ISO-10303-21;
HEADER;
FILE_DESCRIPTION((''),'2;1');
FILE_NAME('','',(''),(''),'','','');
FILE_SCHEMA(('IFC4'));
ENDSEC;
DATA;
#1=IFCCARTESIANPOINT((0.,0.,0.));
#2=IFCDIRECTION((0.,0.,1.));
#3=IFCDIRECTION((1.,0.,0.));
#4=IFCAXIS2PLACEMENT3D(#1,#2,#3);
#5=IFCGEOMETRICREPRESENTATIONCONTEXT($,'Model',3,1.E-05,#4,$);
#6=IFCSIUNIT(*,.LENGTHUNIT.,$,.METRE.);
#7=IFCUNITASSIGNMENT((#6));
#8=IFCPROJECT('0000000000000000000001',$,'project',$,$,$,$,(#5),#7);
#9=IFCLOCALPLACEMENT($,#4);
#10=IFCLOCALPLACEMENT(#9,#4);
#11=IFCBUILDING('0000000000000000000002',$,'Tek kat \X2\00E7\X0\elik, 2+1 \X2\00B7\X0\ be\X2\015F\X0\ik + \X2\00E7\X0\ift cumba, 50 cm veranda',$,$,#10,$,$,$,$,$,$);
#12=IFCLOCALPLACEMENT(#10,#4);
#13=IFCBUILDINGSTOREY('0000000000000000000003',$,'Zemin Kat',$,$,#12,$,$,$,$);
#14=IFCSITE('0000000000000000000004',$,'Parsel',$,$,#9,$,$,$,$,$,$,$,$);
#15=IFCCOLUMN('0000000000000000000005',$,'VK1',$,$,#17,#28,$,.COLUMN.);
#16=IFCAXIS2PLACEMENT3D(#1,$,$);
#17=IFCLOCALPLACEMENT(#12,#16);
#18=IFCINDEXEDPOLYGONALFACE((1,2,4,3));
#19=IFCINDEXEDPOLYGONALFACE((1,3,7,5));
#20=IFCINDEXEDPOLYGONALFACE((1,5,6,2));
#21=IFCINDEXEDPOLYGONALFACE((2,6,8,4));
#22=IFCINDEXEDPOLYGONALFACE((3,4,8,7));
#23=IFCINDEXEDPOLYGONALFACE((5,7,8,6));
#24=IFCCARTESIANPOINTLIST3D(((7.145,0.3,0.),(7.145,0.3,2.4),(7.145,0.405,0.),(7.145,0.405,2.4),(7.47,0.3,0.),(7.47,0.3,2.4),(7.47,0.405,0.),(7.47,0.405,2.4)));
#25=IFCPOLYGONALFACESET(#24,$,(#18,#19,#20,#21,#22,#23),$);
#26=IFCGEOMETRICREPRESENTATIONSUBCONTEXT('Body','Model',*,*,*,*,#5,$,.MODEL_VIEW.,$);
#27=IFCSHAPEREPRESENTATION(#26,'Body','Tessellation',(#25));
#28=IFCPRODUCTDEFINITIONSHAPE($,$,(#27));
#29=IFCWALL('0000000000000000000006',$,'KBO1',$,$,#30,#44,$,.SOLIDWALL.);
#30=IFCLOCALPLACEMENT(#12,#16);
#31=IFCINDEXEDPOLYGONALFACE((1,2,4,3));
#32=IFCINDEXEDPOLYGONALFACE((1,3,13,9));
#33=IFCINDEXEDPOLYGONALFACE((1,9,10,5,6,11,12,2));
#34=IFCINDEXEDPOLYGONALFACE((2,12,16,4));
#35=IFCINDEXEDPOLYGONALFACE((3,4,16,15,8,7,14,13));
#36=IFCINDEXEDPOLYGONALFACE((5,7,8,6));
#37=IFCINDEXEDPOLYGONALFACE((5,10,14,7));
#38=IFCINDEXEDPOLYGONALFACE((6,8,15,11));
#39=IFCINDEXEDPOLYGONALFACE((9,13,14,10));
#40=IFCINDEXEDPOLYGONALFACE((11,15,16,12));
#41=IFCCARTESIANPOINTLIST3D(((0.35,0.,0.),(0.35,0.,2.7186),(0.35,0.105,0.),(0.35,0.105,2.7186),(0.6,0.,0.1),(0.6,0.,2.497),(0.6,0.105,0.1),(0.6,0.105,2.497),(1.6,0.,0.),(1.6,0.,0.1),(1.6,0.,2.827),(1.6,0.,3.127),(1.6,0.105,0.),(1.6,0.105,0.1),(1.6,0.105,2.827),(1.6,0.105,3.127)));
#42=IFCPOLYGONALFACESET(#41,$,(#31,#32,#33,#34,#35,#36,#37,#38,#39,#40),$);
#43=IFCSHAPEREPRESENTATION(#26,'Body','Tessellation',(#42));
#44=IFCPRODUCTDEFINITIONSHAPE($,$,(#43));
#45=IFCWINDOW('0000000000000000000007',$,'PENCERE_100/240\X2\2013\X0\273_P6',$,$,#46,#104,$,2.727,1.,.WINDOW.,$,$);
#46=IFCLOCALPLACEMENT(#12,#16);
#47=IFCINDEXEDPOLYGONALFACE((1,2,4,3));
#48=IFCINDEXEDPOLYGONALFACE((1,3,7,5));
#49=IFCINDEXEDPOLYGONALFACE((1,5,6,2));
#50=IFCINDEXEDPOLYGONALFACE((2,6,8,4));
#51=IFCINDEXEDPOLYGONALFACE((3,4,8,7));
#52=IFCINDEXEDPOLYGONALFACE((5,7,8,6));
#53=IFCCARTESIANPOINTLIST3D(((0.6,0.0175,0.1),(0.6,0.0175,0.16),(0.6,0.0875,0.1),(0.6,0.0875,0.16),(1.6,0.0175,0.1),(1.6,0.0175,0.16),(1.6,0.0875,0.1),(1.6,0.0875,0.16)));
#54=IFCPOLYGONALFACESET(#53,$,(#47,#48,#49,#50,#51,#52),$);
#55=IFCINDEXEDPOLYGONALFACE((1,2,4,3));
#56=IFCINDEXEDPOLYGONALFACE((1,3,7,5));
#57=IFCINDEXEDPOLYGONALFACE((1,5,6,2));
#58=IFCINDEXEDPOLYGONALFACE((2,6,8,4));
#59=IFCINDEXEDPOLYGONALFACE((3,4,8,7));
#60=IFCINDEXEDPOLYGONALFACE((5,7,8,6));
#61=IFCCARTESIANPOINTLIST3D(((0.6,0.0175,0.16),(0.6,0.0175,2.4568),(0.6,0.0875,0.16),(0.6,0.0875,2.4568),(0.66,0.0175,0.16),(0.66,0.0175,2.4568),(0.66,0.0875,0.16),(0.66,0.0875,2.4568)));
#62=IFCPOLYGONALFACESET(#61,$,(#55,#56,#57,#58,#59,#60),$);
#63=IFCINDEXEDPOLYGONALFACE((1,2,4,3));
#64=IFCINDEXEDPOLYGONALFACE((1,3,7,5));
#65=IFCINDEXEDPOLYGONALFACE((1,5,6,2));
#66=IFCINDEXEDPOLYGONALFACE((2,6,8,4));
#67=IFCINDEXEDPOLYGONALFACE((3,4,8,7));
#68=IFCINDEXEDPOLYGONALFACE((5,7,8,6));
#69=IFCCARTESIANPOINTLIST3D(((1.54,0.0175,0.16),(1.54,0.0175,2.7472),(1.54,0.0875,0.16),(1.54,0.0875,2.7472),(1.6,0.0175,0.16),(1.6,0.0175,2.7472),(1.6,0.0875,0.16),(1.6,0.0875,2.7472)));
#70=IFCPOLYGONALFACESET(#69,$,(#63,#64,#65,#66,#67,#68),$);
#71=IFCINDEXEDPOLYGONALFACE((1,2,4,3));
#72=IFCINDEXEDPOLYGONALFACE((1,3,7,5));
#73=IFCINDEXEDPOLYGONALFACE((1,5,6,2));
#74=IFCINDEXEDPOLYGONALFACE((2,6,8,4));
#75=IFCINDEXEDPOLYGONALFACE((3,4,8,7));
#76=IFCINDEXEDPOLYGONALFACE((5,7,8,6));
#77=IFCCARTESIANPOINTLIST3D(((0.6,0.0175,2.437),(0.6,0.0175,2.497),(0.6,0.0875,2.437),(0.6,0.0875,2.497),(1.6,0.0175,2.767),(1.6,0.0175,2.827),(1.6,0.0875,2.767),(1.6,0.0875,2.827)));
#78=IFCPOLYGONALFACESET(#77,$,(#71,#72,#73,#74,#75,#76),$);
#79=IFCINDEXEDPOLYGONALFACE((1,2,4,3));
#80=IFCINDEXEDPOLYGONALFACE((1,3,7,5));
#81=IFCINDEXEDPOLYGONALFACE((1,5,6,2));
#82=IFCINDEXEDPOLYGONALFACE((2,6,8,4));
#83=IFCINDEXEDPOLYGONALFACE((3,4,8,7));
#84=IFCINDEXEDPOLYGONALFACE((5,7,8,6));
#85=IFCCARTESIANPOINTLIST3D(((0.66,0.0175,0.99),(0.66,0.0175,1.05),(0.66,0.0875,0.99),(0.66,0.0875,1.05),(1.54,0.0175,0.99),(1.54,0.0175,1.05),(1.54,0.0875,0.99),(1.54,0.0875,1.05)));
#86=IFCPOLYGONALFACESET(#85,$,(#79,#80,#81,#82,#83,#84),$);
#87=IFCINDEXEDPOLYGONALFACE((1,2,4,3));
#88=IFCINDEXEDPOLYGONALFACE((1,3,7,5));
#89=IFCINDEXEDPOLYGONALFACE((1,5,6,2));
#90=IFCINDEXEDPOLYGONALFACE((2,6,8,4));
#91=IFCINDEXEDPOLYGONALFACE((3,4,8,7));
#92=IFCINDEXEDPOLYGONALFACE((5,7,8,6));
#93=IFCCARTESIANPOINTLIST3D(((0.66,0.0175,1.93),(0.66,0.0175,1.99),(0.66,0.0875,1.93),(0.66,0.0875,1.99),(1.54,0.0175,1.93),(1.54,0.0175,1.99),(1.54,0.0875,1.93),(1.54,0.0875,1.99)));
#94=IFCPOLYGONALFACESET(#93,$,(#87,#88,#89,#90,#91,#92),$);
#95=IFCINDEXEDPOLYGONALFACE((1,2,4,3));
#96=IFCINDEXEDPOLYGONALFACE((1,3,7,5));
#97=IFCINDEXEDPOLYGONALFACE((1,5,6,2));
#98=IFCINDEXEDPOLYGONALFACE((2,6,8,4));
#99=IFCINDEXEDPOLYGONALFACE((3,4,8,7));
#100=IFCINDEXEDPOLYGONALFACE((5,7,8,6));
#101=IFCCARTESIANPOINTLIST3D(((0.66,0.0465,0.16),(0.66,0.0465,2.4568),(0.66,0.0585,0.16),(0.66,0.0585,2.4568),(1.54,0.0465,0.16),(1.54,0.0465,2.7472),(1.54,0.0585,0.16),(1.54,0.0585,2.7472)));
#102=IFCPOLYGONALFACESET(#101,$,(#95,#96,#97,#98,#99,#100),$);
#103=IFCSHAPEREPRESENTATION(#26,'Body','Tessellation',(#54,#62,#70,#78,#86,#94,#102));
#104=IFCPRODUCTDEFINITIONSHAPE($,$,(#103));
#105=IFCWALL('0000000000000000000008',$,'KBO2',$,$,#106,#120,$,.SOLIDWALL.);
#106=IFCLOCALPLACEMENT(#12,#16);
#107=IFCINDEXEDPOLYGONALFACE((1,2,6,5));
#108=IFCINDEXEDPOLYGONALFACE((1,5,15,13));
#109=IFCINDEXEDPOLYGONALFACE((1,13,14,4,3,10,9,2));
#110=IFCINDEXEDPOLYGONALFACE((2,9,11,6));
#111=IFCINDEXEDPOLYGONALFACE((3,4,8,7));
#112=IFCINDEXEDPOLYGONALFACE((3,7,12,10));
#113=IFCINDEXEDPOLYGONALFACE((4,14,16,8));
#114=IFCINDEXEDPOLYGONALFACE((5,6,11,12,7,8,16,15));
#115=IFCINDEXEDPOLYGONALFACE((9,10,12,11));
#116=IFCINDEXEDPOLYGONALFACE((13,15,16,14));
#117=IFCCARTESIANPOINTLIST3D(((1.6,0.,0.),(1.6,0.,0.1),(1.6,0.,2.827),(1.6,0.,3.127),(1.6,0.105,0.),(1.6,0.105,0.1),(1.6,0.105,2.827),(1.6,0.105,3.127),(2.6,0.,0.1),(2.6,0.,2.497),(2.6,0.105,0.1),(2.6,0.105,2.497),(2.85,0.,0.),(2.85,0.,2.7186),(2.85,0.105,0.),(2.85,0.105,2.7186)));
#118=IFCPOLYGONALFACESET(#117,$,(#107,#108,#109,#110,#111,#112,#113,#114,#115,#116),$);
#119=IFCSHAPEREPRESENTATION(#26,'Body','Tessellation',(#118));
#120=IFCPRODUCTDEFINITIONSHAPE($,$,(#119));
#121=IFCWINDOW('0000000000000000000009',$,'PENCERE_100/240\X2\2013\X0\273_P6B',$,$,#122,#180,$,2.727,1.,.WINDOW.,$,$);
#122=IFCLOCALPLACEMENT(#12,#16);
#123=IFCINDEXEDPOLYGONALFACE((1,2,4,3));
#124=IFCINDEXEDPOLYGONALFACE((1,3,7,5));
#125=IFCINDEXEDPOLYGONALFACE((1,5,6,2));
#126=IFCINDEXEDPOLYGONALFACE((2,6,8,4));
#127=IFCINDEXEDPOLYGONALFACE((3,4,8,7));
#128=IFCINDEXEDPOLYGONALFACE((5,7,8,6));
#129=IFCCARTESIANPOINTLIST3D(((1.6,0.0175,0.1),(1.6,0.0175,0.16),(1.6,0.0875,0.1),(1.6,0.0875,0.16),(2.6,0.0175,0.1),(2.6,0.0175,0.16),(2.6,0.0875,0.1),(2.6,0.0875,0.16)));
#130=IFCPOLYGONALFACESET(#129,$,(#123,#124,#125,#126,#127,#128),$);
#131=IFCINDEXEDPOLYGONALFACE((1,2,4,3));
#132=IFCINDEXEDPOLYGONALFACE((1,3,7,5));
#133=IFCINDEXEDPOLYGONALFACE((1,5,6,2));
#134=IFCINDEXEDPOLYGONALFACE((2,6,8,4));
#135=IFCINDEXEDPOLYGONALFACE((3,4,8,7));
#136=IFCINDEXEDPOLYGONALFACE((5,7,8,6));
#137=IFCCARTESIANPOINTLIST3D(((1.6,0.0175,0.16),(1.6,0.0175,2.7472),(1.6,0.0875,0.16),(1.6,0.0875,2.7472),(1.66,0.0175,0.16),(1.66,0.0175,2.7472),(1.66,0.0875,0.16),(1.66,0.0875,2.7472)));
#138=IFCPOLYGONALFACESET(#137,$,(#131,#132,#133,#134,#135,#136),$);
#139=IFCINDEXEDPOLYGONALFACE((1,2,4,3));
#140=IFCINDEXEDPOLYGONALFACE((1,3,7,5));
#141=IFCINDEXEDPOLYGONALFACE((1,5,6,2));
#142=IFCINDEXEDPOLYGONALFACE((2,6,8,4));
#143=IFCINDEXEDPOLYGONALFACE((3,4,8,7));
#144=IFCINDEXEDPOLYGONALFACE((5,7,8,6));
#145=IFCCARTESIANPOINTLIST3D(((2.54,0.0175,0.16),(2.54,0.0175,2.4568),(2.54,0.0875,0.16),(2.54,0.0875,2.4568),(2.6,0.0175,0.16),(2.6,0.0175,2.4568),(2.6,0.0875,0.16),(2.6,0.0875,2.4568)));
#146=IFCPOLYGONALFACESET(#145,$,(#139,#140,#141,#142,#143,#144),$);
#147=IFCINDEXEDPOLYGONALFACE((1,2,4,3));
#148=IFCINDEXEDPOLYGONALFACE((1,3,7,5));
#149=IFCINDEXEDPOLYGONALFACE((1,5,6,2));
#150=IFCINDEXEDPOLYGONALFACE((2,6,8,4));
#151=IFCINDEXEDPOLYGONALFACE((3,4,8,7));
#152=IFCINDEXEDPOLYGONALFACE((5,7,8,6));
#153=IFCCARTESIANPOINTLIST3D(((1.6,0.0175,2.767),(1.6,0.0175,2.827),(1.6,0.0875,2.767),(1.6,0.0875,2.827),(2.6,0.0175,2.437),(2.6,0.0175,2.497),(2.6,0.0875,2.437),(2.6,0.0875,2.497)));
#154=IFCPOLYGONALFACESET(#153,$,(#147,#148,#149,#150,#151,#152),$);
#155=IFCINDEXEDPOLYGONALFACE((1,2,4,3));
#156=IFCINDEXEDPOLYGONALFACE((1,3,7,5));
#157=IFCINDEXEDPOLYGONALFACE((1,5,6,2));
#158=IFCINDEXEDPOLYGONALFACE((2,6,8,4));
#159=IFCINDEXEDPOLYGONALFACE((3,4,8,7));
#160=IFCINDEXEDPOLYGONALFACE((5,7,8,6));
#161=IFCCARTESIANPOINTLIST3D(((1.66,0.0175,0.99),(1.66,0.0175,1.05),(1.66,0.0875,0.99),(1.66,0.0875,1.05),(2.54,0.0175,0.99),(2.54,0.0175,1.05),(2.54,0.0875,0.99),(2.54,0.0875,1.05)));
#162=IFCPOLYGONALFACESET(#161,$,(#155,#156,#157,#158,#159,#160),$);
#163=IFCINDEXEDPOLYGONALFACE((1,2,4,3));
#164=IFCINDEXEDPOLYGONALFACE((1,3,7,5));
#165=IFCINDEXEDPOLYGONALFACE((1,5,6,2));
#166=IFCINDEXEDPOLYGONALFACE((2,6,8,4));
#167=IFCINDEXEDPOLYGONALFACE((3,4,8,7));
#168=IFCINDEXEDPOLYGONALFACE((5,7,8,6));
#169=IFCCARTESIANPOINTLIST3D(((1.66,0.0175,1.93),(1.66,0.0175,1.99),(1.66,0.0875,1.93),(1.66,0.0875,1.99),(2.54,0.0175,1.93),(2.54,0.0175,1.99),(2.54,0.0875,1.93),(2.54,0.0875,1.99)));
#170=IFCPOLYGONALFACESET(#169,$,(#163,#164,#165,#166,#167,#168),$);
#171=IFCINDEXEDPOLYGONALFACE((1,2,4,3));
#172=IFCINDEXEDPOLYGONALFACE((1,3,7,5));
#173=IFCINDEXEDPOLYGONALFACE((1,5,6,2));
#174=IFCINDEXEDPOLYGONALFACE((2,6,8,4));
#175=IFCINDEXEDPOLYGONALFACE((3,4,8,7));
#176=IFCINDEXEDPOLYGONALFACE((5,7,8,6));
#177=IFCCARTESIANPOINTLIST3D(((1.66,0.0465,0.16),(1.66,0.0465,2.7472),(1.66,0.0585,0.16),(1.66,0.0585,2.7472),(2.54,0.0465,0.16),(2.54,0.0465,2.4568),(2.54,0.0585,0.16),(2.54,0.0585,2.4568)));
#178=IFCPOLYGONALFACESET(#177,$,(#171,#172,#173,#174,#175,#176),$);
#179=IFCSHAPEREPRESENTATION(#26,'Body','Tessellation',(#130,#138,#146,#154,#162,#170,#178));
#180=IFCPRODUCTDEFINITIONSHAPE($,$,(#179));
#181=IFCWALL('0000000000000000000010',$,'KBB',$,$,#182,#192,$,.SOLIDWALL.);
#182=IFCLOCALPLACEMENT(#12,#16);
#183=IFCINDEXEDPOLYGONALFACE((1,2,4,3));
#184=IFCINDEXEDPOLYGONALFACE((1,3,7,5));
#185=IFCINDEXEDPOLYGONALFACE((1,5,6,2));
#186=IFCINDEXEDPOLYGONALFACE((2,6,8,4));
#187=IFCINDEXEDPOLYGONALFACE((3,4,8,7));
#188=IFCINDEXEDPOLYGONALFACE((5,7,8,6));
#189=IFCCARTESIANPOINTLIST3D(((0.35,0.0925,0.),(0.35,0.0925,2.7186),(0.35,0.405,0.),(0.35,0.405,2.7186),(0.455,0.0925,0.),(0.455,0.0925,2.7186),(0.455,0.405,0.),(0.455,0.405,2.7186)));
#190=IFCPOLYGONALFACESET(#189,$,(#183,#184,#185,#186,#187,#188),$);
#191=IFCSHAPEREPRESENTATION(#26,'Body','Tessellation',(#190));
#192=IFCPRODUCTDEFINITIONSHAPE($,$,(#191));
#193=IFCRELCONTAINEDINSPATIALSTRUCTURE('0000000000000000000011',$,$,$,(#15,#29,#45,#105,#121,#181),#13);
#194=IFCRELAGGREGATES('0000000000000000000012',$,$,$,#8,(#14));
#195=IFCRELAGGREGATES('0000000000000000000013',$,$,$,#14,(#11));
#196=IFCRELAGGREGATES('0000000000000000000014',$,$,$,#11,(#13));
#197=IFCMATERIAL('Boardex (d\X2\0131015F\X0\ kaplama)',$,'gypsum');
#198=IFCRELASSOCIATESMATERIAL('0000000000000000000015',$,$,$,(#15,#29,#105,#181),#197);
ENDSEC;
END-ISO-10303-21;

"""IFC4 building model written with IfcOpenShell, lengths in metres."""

from ifc_helpers import new_model, si_unit, frame, origin_with_axes, place, context, subcontext, project, spatial, line, indexed_curve, outline, extrude, material, element, fill, save


model = new_model("IFC4")

# Units and contexts
model_context = context("Model", 3, precision=1e-05, world=origin_with_axes())
body_context = subcontext(model_context, "Body", "Model", "MODEL_VIEW")
ifc_project = project(units=[si_unit("LENGTHUNIT", "METRE")], contexts=[model_context])

# Site, building, storey
site_placement = place(None, origin_with_axes())
site = spatial("IfcSite", under=ifc_project, at=site_placement, Name="Parsel")
building_placement = place(site_placement, origin_with_axes())
building = spatial("IfcBuilding", under=site, at=building_placement, Name="Tek kat çelik, 2+1 · beşik + çift cumba, 50 cm veranda")
storey_placement = place(building_placement, origin_with_axes())
storey = spatial("IfcBuildingStorey", under=building, at=storey_placement, Name="Zemin Kat")

# Column
ifc_material_1 = material(Name="Boardex (dış kaplama)", Category="gypsum")
column_placement = place(storey_placement, origin_with_axes())
element("IfcColumn", 1, at=column_placement, inside=storey, material=ifc_material_1, Name="VK1", PredefinedType="COLUMN", context=body_context, shape_type="SweptSolid", body=[
    extrude(outline(indexed_curve([(0.0, 0.0), (0.325, 0.0), (0.325, 0.105), (0.0, 0.105)], segments=[line(1, 2, 3, 4, 1)])), frame((7.145, 0.3, 0.0), z_axis=(0.0, 0.0, 1.0), x_axis=(1.0, 0.0, 0.0)), (0.0, 0.0, 1.0), 2.4),
])

# Walls, openings, windows
wall_1_placement = place(storey_placement, origin_with_axes())
wall_1 = element("IfcWall", 2, at=wall_1_placement, inside=storey, material=ifc_material_1, Name="KBO1", PredefinedType="SOLIDWALL", context=body_context, shape_type="SweptSolid", body=[
    extrude(outline(indexed_curve([(0.35, 0.0), (1.6, 0.0), (1.6, 3.127), (0.35, 2.7186)], segments=[line(1, 2, 3, 4, 1)])), frame((0.0, 0.105, 0.0), z_axis=(0.0, -1.0, 0.0), x_axis=(1.0, 0.0, 0.0)), (0.0, 0.0, 1.0), 0.105),
])
opening_1_placement = place(wall_1_placement, origin_with_axes())
opening_1 = element("IfcOpeningElement", 3, at=opening_1_placement, cuts=wall_1, PredefinedType="OPENING", context=body_context, shape_type="SweptSolid", body=[
    extrude(outline(indexed_curve([(0.6, 0.1), (1.6, 0.1), (1.6, 2.827), (0.6, 2.497)], segments=[line(1, 2, 3, 4, 1)])), frame((0.0, 0.125, 0.0), z_axis=(0.0, -1.0, 0.0), x_axis=(1.0, 0.0, 0.0)), (0.0, 0.0, 1.0), 0.145),
])
window_1_placement = place(storey_placement, origin_with_axes())
window_1 = element("IfcWindow", 4, at=window_1_placement, inside=storey, Name="PENCERE_100/240–273_P6", OverallHeight=2.727, OverallWidth=1.0, PredefinedType="WINDOW", context=body_context, shape_type="SweptSolid", body=[
    extrude(outline(indexed_curve([(0.0, 0.0), (1.0, 0.0), (1.0, 0.07), (0.0, 0.07)], segments=[line(1, 2, 3, 4, 1)])), frame((0.6, 0.0175, 0.1), z_axis=(0.0, 0.0, 1.0), x_axis=(1.0, 0.0, 0.0)), (0.0, 0.0, 1.0), 0.06),
    extrude(outline(indexed_curve([(0.0, 0.0), (0.06, 0.0), (0.06, 0.07), (0.0, 0.07)], segments=[line(1, 2, 3, 4, 1)])), frame((0.6, 0.0175, 0.16), z_axis=(0.0, 0.0, 1.0), x_axis=(1.0, 0.0, 0.0)), (0.0, 0.0, 1.0), 2.2968),
    extrude(outline(indexed_curve([(0.0, 0.0), (0.06, 0.0), (0.06, 0.07), (0.0, 0.07)], segments=[line(1, 2, 3, 4, 1)])), frame((1.54, 0.0175, 0.16), z_axis=(0.0, 0.0, 1.0), x_axis=(1.0, 0.0, 0.0)), (0.0, 0.0, 1.0), 2.5872),
    extrude(outline(indexed_curve([(0.6, 2.437), (1.6, 2.767), (1.6, 2.827), (0.6, 2.497)], segments=[line(1, 2, 3, 4, 1)])), frame((0.0, 0.0875, 0.0), z_axis=(0.0, -1.0, 0.0), x_axis=(1.0, 0.0, 0.0)), (0.0, 0.0, 1.0), 0.07),
    extrude(outline(indexed_curve([(0.0, 0.0), (0.88, 0.0), (0.88, 0.07), (0.0, 0.07)], segments=[line(1, 2, 3, 4, 1)])), frame((0.66, 0.0175, 0.99), z_axis=(0.0, 0.0, 1.0), x_axis=(1.0, 0.0, 0.0)), (0.0, 0.0, 1.0), 0.06),
    extrude(outline(indexed_curve([(0.0, 0.0), (0.88, 0.0), (0.88, 0.07), (0.0, 0.07)], segments=[line(1, 2, 3, 4, 1)])), frame((0.66, 0.0175, 1.93), z_axis=(0.0, 0.0, 1.0), x_axis=(1.0, 0.0, 0.0)), (0.0, 0.0, 1.0), 0.06),
    extrude(outline(indexed_curve([(0.66, 0.16), (1.54, 0.16), (1.54, 2.7472), (0.66, 2.4568)], segments=[line(1, 2, 3, 4, 1)])), frame((0.0, 0.0585, 0.0), z_axis=(0.0, -1.0, 0.0), x_axis=(1.0, 0.0, 0.0)), (0.0, 0.0, 1.0), 0.012),
])
fill(opening_1, window_1)
wall_2_placement = place(storey_placement, origin_with_axes())
wall_2 = element("IfcWall", 5, at=wall_2_placement, inside=storey, material=ifc_material_1, Name="KBO2", PredefinedType="SOLIDWALL", context=body_context, shape_type="SweptSolid", body=[
    extrude(outline(indexed_curve([(1.6, 0.0), (2.85, 0.0), (2.85, 2.7186), (1.6, 3.127)], segments=[line(1, 2, 3, 4, 1)])), frame((0.0, 0.105, 0.0), z_axis=(0.0, -1.0, 0.0), x_axis=(1.0, 0.0, 0.0)), (0.0, 0.0, 1.0), 0.105),
])
opening_2_placement = place(wall_2_placement, origin_with_axes())
opening_2 = element("IfcOpeningElement", 6, at=opening_2_placement, cuts=wall_2, PredefinedType="OPENING", context=body_context, shape_type="SweptSolid", body=[
    extrude(outline(indexed_curve([(1.6, 0.1), (2.6, 0.1), (2.6, 2.497), (1.6, 2.827)], segments=[line(1, 2, 3, 4, 1)])), frame((0.0, 0.125, 0.0), z_axis=(0.0, -1.0, 0.0), x_axis=(1.0, 0.0, 0.0)), (0.0, 0.0, 1.0), 0.145),
])
window_2_placement = place(storey_placement, origin_with_axes())
window_2 = element("IfcWindow", 7, at=window_2_placement, inside=storey, Name="PENCERE_100/240–273_P6B", OverallHeight=2.727, OverallWidth=1.0, PredefinedType="WINDOW", context=body_context, shape_type="SweptSolid", body=[
    extrude(outline(indexed_curve([(0.0, 0.0), (1.0, 0.0), (1.0, 0.07), (0.0, 0.07)], segments=[line(1, 2, 3, 4, 1)])), frame((1.6, 0.0175, 0.1), z_axis=(0.0, 0.0, 1.0), x_axis=(1.0, 0.0, 0.0)), (0.0, 0.0, 1.0), 0.06),
    extrude(outline(indexed_curve([(0.0, 0.0), (0.06, 0.0), (0.06, 0.07), (0.0, 0.07)], segments=[line(1, 2, 3, 4, 1)])), frame((1.6, 0.0175, 0.16), z_axis=(0.0, 0.0, 1.0), x_axis=(1.0, 0.0, 0.0)), (0.0, 0.0, 1.0), 2.5872),
    extrude(outline(indexed_curve([(0.0, 0.0), (0.06, 0.0), (0.06, 0.07), (0.0, 0.07)], segments=[line(1, 2, 3, 4, 1)])), frame((2.54, 0.0175, 0.16), z_axis=(0.0, 0.0, 1.0), x_axis=(1.0, 0.0, 0.0)), (0.0, 0.0, 1.0), 2.2968),
    extrude(outline(indexed_curve([(1.6, 2.767), (2.6, 2.437), (2.6, 2.497), (1.6, 2.827)], segments=[line(1, 2, 3, 4, 1)])), frame((0.0, 0.0875, 0.0), z_axis=(0.0, -1.0, 0.0), x_axis=(1.0, 0.0, 0.0)), (0.0, 0.0, 1.0), 0.07),
    extrude(outline(indexed_curve([(0.0, 0.0), (0.88, 0.0), (0.88, 0.07), (0.0, 0.07)], segments=[line(1, 2, 3, 4, 1)])), frame((1.66, 0.0175, 0.99), z_axis=(0.0, 0.0, 1.0), x_axis=(1.0, 0.0, 0.0)), (0.0, 0.0, 1.0), 0.06),
    extrude(outline(indexed_curve([(0.0, 0.0), (0.88, 0.0), (0.88, 0.07), (0.0, 0.07)], segments=[line(1, 2, 3, 4, 1)])), frame((1.66, 0.0175, 1.93), z_axis=(0.0, 0.0, 1.0), x_axis=(1.0, 0.0, 0.0)), (0.0, 0.0, 1.0), 0.06),
    extrude(outline(indexed_curve([(1.66, 0.16), (2.54, 0.16), (2.54, 2.4568), (1.66, 2.7472)], segments=[line(1, 2, 3, 4, 1)])), frame((0.0, 0.0585, 0.0), z_axis=(0.0, -1.0, 0.0), x_axis=(1.0, 0.0, 0.0)), (0.0, 0.0, 1.0), 0.012),
])
fill(opening_2, window_2)

# Wall
wall_3_placement = place(storey_placement, origin_with_axes())
element("IfcWall", 8, at=wall_3_placement, inside=storey, material=ifc_material_1, Name="KBB", PredefinedType="SOLIDWALL", context=body_context, shape_type="SweptSolid", body=[
    extrude(outline(indexed_curve([(0.0, 0.0), (0.105, 0.0), (0.105, 0.3125), (0.0, 0.3125)], segments=[line(1, 2, 3, 4, 1)])), frame((0.35, 0.0925, 0.0), z_axis=(0.0, 0.0, 1.0), x_axis=(1.0, 0.0, 0.0)), (0.0, 0.0, 1.0), 2.7186),
])

save(model, "model.ifc")
